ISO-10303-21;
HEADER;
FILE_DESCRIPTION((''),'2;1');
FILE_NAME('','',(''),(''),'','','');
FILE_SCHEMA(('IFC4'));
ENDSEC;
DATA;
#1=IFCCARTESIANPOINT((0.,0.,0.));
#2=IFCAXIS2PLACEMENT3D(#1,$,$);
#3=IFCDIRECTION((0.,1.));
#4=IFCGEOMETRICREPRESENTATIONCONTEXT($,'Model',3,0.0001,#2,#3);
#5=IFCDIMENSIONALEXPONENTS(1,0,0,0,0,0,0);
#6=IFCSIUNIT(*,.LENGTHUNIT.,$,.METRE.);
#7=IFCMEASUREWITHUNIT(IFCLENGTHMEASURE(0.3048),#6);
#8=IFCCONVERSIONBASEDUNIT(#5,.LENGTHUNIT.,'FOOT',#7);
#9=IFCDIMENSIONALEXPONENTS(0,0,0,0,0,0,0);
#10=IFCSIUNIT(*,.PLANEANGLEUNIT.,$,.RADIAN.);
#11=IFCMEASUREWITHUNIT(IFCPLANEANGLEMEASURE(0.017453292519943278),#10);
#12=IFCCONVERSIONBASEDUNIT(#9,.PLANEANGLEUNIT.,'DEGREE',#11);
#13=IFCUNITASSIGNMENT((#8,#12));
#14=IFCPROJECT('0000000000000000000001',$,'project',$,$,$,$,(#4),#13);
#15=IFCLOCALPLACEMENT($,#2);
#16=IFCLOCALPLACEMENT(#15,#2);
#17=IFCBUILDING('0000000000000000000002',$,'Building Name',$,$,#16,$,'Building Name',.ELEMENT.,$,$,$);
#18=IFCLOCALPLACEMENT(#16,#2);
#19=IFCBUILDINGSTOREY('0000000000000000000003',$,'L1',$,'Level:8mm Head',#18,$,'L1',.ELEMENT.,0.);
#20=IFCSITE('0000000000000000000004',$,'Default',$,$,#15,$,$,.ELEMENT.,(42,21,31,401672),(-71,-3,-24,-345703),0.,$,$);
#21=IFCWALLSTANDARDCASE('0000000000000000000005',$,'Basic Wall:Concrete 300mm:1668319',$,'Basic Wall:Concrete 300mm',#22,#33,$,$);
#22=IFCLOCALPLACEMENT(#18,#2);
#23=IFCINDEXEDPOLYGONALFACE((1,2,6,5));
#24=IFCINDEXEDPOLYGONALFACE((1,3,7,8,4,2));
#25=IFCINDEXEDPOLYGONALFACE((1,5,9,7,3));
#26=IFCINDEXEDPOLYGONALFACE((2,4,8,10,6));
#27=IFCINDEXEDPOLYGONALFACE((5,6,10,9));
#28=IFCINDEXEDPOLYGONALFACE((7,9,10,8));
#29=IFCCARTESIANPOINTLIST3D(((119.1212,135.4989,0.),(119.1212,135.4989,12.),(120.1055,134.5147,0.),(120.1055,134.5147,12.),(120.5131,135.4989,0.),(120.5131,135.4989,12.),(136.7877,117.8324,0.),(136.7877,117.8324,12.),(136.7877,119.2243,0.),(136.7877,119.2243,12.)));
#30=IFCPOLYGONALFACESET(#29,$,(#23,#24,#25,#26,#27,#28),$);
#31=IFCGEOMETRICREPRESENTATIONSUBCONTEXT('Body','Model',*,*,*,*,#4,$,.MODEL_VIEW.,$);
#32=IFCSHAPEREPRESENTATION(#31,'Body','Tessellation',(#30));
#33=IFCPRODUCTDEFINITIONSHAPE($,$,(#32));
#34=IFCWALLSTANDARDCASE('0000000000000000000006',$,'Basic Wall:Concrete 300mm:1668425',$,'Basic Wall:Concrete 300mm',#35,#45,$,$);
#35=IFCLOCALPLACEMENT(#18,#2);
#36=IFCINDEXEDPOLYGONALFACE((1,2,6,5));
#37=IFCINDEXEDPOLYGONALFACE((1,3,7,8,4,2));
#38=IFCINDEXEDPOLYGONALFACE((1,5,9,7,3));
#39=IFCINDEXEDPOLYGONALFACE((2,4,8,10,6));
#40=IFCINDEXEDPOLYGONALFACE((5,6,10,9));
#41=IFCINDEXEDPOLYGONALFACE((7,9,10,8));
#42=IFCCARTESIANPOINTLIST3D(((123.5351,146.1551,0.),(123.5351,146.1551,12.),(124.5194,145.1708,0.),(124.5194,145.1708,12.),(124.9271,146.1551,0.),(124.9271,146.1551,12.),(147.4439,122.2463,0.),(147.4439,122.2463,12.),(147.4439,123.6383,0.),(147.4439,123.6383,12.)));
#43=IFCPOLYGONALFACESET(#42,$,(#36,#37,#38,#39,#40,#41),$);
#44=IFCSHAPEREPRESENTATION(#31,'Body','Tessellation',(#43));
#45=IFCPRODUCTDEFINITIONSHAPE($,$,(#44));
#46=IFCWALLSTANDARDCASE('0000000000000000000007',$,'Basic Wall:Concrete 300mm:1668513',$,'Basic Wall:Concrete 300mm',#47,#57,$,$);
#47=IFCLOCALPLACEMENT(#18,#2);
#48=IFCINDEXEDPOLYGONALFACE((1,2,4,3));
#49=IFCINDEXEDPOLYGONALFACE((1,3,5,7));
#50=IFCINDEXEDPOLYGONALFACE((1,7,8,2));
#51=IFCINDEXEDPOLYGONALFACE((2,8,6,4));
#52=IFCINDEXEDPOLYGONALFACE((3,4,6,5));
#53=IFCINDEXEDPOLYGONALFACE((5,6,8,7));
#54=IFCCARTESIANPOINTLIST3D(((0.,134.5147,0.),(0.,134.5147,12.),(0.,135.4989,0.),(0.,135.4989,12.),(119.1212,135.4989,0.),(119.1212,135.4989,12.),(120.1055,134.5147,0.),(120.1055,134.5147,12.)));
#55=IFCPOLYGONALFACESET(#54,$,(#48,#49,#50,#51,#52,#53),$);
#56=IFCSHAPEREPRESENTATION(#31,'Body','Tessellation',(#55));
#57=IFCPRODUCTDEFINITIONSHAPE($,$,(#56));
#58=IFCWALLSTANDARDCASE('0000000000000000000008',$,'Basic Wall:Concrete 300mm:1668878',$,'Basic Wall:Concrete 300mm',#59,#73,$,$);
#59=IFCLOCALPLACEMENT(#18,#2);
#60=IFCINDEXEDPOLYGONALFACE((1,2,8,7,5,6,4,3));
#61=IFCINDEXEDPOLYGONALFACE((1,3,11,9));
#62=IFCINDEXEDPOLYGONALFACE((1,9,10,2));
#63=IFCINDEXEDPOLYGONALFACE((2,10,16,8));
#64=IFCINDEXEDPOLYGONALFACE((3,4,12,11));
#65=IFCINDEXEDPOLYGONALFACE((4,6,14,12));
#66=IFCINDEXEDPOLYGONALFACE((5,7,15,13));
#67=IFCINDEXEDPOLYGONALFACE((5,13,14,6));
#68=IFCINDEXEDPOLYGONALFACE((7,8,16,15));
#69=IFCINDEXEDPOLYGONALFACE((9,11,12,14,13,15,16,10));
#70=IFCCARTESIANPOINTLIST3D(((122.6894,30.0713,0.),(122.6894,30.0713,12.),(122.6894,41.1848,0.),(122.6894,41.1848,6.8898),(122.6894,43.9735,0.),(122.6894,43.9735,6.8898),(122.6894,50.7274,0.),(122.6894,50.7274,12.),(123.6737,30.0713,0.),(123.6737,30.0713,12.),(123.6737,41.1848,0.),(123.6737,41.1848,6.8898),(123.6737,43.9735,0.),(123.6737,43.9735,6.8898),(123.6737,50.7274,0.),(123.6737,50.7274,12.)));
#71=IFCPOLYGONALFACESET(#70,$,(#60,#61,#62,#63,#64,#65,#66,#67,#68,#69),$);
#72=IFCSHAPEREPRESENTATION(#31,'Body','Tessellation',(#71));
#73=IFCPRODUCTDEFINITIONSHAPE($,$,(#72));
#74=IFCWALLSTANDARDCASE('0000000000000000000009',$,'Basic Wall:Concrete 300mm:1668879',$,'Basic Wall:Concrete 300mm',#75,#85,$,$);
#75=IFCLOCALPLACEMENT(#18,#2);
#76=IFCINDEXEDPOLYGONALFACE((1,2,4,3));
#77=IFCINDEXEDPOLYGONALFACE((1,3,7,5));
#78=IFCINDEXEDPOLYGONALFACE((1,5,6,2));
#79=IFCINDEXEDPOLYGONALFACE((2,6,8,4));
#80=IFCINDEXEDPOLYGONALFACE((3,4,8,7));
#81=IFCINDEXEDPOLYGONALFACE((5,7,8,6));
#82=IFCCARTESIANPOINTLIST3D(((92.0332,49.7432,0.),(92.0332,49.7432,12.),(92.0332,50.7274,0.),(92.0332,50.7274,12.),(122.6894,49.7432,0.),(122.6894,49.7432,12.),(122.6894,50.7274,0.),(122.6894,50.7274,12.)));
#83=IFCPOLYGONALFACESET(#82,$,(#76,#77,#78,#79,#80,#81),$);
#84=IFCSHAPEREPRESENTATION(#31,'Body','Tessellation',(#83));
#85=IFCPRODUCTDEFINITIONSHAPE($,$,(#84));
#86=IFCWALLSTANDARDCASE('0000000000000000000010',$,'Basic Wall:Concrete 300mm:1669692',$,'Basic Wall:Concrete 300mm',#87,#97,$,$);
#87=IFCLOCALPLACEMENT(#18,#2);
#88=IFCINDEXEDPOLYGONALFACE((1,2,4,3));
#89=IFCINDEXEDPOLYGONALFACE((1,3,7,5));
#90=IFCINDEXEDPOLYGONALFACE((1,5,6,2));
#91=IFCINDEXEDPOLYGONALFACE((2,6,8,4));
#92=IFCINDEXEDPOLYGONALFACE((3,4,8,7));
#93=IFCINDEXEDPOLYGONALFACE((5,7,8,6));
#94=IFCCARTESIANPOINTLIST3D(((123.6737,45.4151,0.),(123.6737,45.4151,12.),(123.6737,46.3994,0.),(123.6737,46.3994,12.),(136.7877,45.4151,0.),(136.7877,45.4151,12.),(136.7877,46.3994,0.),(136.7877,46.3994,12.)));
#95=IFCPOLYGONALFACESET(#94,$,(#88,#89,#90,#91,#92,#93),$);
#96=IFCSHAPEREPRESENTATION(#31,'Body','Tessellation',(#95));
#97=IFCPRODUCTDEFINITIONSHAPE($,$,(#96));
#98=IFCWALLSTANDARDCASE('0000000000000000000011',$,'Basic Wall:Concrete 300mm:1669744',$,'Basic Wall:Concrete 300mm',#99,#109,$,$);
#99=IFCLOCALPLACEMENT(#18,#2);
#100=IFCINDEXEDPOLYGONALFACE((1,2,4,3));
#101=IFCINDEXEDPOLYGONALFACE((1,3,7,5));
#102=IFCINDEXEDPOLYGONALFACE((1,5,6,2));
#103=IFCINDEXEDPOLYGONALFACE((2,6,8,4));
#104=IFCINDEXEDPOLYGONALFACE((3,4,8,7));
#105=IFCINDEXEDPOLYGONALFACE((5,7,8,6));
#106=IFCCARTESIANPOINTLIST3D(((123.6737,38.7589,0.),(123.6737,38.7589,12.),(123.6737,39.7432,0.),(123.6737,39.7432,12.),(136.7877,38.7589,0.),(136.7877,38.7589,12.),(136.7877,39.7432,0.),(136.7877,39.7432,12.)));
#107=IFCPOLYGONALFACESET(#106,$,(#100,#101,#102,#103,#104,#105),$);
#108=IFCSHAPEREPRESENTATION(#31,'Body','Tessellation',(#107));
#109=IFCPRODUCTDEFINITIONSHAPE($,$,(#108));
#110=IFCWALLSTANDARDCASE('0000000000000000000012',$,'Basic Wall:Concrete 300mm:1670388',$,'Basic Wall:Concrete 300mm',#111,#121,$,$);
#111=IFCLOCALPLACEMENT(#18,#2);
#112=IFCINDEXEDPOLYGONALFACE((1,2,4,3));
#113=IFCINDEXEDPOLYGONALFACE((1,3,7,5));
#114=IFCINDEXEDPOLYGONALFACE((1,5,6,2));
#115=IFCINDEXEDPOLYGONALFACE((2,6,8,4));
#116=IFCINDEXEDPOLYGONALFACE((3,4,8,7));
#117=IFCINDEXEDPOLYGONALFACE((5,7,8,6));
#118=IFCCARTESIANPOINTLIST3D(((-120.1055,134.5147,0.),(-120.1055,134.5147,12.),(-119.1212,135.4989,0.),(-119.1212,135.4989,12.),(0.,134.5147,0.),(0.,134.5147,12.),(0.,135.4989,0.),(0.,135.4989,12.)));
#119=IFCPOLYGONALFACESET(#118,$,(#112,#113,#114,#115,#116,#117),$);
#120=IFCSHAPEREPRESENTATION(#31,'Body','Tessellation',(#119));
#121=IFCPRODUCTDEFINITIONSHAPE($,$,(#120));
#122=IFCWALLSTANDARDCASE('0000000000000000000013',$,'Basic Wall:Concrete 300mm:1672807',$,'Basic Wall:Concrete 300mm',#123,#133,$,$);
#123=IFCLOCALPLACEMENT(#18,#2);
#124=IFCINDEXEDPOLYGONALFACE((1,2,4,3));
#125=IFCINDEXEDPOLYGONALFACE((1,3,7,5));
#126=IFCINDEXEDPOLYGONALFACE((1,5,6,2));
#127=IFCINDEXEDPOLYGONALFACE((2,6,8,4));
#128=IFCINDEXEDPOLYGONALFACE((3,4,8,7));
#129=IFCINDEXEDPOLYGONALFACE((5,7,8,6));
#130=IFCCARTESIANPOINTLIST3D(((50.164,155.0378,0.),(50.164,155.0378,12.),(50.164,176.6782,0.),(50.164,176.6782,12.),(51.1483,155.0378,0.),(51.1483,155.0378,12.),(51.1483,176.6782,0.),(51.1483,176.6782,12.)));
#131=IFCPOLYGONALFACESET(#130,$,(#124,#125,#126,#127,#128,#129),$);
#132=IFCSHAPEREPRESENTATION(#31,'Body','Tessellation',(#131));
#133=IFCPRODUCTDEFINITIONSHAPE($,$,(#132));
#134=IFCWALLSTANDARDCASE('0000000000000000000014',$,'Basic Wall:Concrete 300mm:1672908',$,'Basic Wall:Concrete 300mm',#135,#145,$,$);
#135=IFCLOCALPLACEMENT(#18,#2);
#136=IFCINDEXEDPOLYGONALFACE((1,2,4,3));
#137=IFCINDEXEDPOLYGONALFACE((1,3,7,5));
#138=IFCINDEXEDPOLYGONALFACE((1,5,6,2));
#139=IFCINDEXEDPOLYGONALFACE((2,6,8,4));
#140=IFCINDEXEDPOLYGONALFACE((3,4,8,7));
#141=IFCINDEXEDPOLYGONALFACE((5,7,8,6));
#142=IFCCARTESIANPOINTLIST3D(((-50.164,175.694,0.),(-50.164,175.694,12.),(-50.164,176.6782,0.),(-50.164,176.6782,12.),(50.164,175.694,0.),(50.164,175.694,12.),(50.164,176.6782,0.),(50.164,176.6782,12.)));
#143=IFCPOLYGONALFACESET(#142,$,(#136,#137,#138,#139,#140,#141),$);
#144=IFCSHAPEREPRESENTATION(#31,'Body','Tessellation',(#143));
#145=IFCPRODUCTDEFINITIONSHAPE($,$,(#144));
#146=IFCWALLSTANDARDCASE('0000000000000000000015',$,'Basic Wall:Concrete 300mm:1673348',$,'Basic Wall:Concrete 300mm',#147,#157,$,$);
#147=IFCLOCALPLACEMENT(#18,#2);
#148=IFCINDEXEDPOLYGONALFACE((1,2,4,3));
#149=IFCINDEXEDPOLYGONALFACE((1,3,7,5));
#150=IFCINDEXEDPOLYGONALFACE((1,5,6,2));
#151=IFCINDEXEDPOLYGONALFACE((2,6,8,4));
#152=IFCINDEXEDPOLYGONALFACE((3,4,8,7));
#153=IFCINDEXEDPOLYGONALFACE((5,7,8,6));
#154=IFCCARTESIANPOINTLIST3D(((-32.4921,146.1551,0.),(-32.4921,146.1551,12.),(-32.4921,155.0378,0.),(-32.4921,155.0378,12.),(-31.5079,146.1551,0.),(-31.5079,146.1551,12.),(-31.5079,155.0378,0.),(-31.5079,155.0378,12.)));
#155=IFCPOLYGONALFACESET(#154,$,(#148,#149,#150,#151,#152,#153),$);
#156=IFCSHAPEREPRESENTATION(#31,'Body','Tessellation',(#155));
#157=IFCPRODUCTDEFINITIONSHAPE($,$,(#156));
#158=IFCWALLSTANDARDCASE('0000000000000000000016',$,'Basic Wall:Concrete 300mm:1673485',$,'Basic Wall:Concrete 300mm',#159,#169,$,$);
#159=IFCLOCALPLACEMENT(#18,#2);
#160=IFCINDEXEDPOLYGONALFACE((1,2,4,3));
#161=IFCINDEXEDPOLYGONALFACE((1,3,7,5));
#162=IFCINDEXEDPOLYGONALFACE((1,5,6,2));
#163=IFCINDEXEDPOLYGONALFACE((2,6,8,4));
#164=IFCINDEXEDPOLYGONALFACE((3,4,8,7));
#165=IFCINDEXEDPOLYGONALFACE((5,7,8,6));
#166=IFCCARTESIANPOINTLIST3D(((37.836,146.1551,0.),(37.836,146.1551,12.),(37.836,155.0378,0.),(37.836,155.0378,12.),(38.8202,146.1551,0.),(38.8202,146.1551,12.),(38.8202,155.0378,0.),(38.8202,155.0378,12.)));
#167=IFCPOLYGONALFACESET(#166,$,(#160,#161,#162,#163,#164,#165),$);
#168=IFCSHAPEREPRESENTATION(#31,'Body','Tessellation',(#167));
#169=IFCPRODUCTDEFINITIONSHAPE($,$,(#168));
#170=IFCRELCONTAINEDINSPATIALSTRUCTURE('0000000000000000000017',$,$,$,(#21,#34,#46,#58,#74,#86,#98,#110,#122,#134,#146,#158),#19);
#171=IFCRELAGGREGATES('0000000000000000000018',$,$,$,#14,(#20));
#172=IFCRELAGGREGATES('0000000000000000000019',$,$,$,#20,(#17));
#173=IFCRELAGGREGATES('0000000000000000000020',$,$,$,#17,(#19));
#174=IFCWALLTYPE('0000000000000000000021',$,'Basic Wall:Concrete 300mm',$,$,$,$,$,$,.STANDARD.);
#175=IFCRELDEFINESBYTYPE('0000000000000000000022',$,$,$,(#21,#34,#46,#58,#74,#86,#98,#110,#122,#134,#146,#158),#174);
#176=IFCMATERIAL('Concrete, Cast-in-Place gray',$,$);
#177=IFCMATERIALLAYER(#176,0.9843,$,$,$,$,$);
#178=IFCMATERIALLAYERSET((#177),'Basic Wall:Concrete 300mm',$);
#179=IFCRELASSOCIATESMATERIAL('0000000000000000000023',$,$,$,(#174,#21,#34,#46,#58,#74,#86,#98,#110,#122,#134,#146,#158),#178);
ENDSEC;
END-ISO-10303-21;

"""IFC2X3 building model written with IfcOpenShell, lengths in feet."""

from ifc_helpers import new_model, entity, si_unit, converted_unit, direction, frame, frame_2d, origin, place, context, subcontext, project, spatial, polyline, rectangle, outline, extrude, material, layer, layer_set, layer_usage, type_object, element, save


model = new_model("IFC2X3")

# Units and contexts
model_context = context("Model", 3, precision=0.0001, world=origin(), true_north=direction((0.0, 1.0)))
body_context = subcontext(model_context, "Body", "Model", "MODEL_VIEW")
ifc_project = project(units=[converted_unit("LENGTHUNIT", "FOOT", entity("IfcLengthMeasure", 0.3048), si_unit("LENGTHUNIT", "METRE"), dimensions=[1, 0, 0, 0, 0, 0, 0]), converted_unit("PLANEANGLEUNIT", "DEGREE", entity("IfcPlaneAngleMeasure", 0.017453292519943278), si_unit("PLANEANGLEUNIT", "RADIAN"), dimensions=[0, 0, 0, 0, 0, 0, 0])], contexts=[model_context])

# Site, building, storey
site_placement = place(None, origin())
site = spatial("IfcSite", under=ifc_project, at=site_placement, Name="Default", CompositionType="ELEMENT", RefLatitude=(42, 21, 31, 401672), RefLongitude=(-71, -3, -24, -345703), RefElevation=0.0)
building_placement = place(site_placement, origin())
building = spatial("IfcBuilding", under=site, at=building_placement, Name="Building Name", LongName="Building Name", CompositionType="ELEMENT")
storey_placement = place(building_placement, origin())
storey = spatial("IfcBuildingStorey", under=building, at=storey_placement, Name="L1", ObjectType="Level:8mm Head", LongName="L1", CompositionType="ELEMENT", Elevation=0.0)

# Walls
ifc_material_1 = material(Name="Concrete, Cast-in-Place gray")
ifc_layer = layer(ifc_material_1, 0.9843)
ifc_layer_set = layer_set([ifc_layer], Name="Basic Wall:Concrete 300mm")
ifc_layer_usage_1 = layer_usage(ifc_layer_set, "AXIS2", "NEGATIVE", 0.4921)
wall_type = type_object("IfcWallType", Name="Basic Wall:Concrete 300mm", PredefinedType="STANDARD", material=ifc_layer_set)
wall_1_placement = place(storey_placement, frame((137.1357, 118.1804, 0.0), z_axis=(0.0, 0.0, 1.0), x_axis=(-0.707107, 0.707107, 0.0)))
element("IfcWallStandardCase", 1, at=wall_1_placement, inside=storey, type_object=wall_type, material=ifc_layer_usage_1, Name="Basic Wall:Concrete 300mm:1668319", ObjectType="Basic Wall:Concrete 300mm", context=body_context, shape_type="SweptSolid", body=[
    extrude(outline(polyline([(24.0, -0.4921), (24.9843, 0.4921), (23.5923, 0.4921), (0.0, 0.4921), (0.9843, -0.4921), (24.0, -0.4921)])), origin(), (0.0, 0.0, 1.0), 12.0),
])
ifc_layer_usage_2 = layer_usage(ifc_layer_set, "AXIS2", "NEGATIVE", 0.4921)
wall_2_placement = place(storey_placement, frame((123.8831, 146.5031, 0.0), z_axis=(0.0, 0.0, 1.0), x_axis=(0.707107, -0.707107, 0.0)))
element("IfcWallStandardCase", 2, at=wall_2_placement, inside=storey, type_object=wall_type, material=ifc_layer_usage_2, Name="Basic Wall:Concrete 300mm:1668425", ObjectType="Basic Wall:Concrete 300mm", context=body_context, shape_type="SweptSolid", body=[
    extrude(outline(polyline([(33.8121, -0.4921), (32.8279, 0.4921), (0.9843, 0.4921), (0.0, -0.4921), (1.3919, -0.4921), (33.8121, -0.4921)])), origin(), (0.0, 0.0, 1.0), 12.0),
])
ifc_layer_usage_3 = layer_usage(ifc_layer_set, "AXIS2", "NEGATIVE", 0.4921)
wall_3_placement = place(storey_placement, frame((0.0, 135.0068, 0.0)))
element("IfcWallStandardCase", 3, at=wall_3_placement, inside=storey, type_object=wall_type, material=ifc_layer_usage_3, Name="Basic Wall:Concrete 300mm:1668513", ObjectType="Basic Wall:Concrete 300mm", context=body_context, shape_type="SweptSolid", body=[
    extrude(outline(polyline([(120.1055, -0.4921), (119.1212, 0.4921), (0.0, 0.4921), (0.0, -0.4921), (120.1055, -0.4921)])), origin(), (0.0, 0.0, 1.0), 12.0),
])

# Wall, opening
ifc_layer_usage_4 = layer_usage(ifc_layer_set, "AXIS2", "NEGATIVE", 0.4921)
wall_4_placement = place(storey_placement, frame((123.1815, 50.7274, 0.0), z_axis=(0.0, 0.0, 1.0), x_axis=(0.0, -1.0, 0.0)))
wall_4 = element("IfcWallStandardCase", 4, at=wall_4_placement, inside=storey, type_object=wall_type, material=ifc_layer_usage_4, Name="Basic Wall:Concrete 300mm:1668878", ObjectType="Basic Wall:Concrete 300mm", context=body_context, shape_type="SweptSolid", body=[
    extrude(rectangle(XDim=20.6562, YDim=0.9843, at=frame_2d((10.3281, 0.0), x_axis=(1.0, 0.0))), origin(), (0.0, 0.0, 1.0), 12.0),
])
opening_placement = place(wall_4_placement, frame((6.7539, -0.4921, 0.0)))
element("IfcOpeningElement", 5, at=opening_placement, cuts=wall_4, ObjectType="Opening", context=body_context, shape_type="SweptSolid", body=[
    extrude(rectangle(XDim=6.8898, YDim=2.7887, at=frame_2d((3.4449, 1.3944), x_axis=(1.0, 0.0))), frame((0.0, 0.0, 0.0), z_axis=(0.0, 1.0, 0.0), x_axis=(0.0, 0.0, 1.0)), (0.0, 0.0, 1.0), 0.9843),
])

# Walls
ifc_layer_usage_5 = layer_usage(ifc_layer_set, "AXIS2", "NEGATIVE", 0.4921)
wall_5_placement = place(storey_placement, frame((92.0332, 50.2353, 0.0)))
element("IfcWallStandardCase", 6, at=wall_5_placement, inside=storey, type_object=wall_type, material=ifc_layer_usage_5, Name="Basic Wall:Concrete 300mm:1668879", ObjectType="Basic Wall:Concrete 300mm", context=body_context, shape_type="SweptSolid", body=[
    extrude(rectangle(XDim=30.6562, YDim=0.9843, at=frame_2d((15.3281, 0.0), x_axis=(-1.0, 0.0))), origin(), (0.0, 0.0, 1.0), 12.0),
])
ifc_layer_usage_6 = layer_usage(ifc_layer_set, "AXIS2", "NEGATIVE", 0.4921)
wall_6_placement = place(storey_placement, frame((123.6737, 45.9072, 0.0)))
element("IfcWallStandardCase", 7, at=wall_6_placement, inside=storey, type_object=wall_type, material=ifc_layer_usage_6, Name="Basic Wall:Concrete 300mm:1669692", ObjectType="Basic Wall:Concrete 300mm", context=body_context, shape_type="SweptSolid", body=[
    extrude(rectangle(XDim=13.1141, YDim=0.9843, at=frame_2d((6.557, 0.0), x_axis=(-1.0, 0.0))), origin(), (0.0, 0.0, 1.0), 12.0),
])
ifc_layer_usage_7 = layer_usage(ifc_layer_set, "AXIS2", "NEGATIVE", 0.4921)
wall_7_placement = place(storey_placement, frame((123.6737, 39.2511, 0.0)))
element("IfcWallStandardCase", 8, at=wall_7_placement, inside=storey, type_object=wall_type, material=ifc_layer_usage_7, Name="Basic Wall:Concrete 300mm:1669744", ObjectType="Basic Wall:Concrete 300mm", context=body_context, shape_type="SweptSolid", body=[
    extrude(rectangle(XDim=13.1141, YDim=0.9843, at=frame_2d((6.557, 0.0), x_axis=(-1.0, 0.0))), origin(), (0.0, 0.0, 1.0), 12.0),
])
ifc_layer_usage_8 = layer_usage(ifc_layer_set, "AXIS2", "POSITIVE", -0.4921)
wall_8_placement = place(storey_placement, frame((0.0, 135.0068, 0.0), z_axis=(0.0, 0.0, 1.0), x_axis=(-1.0, 0.0, 0.0)))
element("IfcWallStandardCase", 9, at=wall_8_placement, inside=storey, type_object=wall_type, material=ifc_layer_usage_8, Name="Basic Wall:Concrete 300mm:1670388", ObjectType="Basic Wall:Concrete 300mm", context=body_context, shape_type="SweptSolid", body=[
    extrude(outline(polyline([(119.1212, -0.4921), (120.1055, 0.4921), (0.0, 0.4921), (0.0, -0.4921), (119.1212, -0.4921)])), origin(), (0.0, 0.0, 1.0), 12.0),
])
ifc_layer_usage_9 = layer_usage(ifc_layer_set, "AXIS2", "NEGATIVE", 0.4921)
wall_9_placement = place(storey_placement, frame((50.6562, 176.6782, 0.0), z_axis=(0.0, 0.0, 1.0), x_axis=(0.0, -1.0, 0.0)))
element("IfcWallStandardCase", 10, at=wall_9_placement, inside=storey, type_object=wall_type, material=ifc_layer_usage_9, Name="Basic Wall:Concrete 300mm:1672807", ObjectType="Basic Wall:Concrete 300mm", context=body_context, shape_type="SweptSolid", body=[
    extrude(rectangle(XDim=21.6404, YDim=0.9843, at=frame_2d((10.8202, 0.0), x_axis=(-1.0, 0.0))), origin(), (0.0, 0.0, 1.0), 12.0),
])
ifc_layer_usage_10 = layer_usage(ifc_layer_set, "AXIS2", "POSITIVE", -0.4921)
wall_10_placement = place(storey_placement, frame((50.164, 176.1861, 0.0), z_axis=(0.0, 0.0, 1.0), x_axis=(-1.0, 0.0, 0.0)))
element("IfcWallStandardCase", 11, at=wall_10_placement, inside=storey, type_object=wall_type, material=ifc_layer_usage_10, Name="Basic Wall:Concrete 300mm:1672908", ObjectType="Basic Wall:Concrete 300mm", context=body_context, shape_type="SweptSolid", body=[
    extrude(rectangle(XDim=100.3281, YDim=0.9843, at=frame_2d((50.164, 0.0), x_axis=(-1.0, 0.0))), origin(), (0.0, 0.0, 1.0), 12.0),
])
ifc_layer_usage_11 = layer_usage(ifc_layer_set, "AXIS2", "NEGATIVE", 0.4921)
wall_11_placement = place(storey_placement, frame((-32.0, 155.0378, 0.0), z_axis=(0.0, 0.0, 1.0), x_axis=(0.0, -1.0, 0.0)))
element("IfcWallStandardCase", 12, at=wall_11_placement, inside=storey, type_object=wall_type, material=ifc_layer_usage_11, Name="Basic Wall:Concrete 300mm:1673348", ObjectType="Basic Wall:Concrete 300mm", context=body_context, shape_type="SweptSolid", body=[
    extrude(rectangle(XDim=8.8827, YDim=0.9843, at=frame_2d((4.4414, 0.0), x_axis=(-1.0, 0.0))), origin(), (0.0, 0.0, 1.0), 12.0),
])
ifc_layer_usage_12 = layer_usage(ifc_layer_set, "AXIS2", "NEGATIVE", 0.4921)
wall_12_placement = place(storey_placement, frame((38.3281, 155.0378, 0.0), z_axis=(0.0, 0.0, 1.0), x_axis=(0.0, -1.0, 0.0)))
element("IfcWallStandardCase", 13, at=wall_12_placement, inside=storey, type_object=wall_type, material=ifc_layer_usage_12, Name="Basic Wall:Concrete 300mm:1673485", ObjectType="Basic Wall:Concrete 300mm", context=body_context, shape_type="SweptSolid", body=[
    extrude(rectangle(XDim=8.8827, YDim=0.9843, at=frame_2d((4.4414, 0.0), x_axis=(-1.0, 0.0))), origin(), (0.0, 0.0, 1.0), 12.0),
])

save(model, "model.ifc")
